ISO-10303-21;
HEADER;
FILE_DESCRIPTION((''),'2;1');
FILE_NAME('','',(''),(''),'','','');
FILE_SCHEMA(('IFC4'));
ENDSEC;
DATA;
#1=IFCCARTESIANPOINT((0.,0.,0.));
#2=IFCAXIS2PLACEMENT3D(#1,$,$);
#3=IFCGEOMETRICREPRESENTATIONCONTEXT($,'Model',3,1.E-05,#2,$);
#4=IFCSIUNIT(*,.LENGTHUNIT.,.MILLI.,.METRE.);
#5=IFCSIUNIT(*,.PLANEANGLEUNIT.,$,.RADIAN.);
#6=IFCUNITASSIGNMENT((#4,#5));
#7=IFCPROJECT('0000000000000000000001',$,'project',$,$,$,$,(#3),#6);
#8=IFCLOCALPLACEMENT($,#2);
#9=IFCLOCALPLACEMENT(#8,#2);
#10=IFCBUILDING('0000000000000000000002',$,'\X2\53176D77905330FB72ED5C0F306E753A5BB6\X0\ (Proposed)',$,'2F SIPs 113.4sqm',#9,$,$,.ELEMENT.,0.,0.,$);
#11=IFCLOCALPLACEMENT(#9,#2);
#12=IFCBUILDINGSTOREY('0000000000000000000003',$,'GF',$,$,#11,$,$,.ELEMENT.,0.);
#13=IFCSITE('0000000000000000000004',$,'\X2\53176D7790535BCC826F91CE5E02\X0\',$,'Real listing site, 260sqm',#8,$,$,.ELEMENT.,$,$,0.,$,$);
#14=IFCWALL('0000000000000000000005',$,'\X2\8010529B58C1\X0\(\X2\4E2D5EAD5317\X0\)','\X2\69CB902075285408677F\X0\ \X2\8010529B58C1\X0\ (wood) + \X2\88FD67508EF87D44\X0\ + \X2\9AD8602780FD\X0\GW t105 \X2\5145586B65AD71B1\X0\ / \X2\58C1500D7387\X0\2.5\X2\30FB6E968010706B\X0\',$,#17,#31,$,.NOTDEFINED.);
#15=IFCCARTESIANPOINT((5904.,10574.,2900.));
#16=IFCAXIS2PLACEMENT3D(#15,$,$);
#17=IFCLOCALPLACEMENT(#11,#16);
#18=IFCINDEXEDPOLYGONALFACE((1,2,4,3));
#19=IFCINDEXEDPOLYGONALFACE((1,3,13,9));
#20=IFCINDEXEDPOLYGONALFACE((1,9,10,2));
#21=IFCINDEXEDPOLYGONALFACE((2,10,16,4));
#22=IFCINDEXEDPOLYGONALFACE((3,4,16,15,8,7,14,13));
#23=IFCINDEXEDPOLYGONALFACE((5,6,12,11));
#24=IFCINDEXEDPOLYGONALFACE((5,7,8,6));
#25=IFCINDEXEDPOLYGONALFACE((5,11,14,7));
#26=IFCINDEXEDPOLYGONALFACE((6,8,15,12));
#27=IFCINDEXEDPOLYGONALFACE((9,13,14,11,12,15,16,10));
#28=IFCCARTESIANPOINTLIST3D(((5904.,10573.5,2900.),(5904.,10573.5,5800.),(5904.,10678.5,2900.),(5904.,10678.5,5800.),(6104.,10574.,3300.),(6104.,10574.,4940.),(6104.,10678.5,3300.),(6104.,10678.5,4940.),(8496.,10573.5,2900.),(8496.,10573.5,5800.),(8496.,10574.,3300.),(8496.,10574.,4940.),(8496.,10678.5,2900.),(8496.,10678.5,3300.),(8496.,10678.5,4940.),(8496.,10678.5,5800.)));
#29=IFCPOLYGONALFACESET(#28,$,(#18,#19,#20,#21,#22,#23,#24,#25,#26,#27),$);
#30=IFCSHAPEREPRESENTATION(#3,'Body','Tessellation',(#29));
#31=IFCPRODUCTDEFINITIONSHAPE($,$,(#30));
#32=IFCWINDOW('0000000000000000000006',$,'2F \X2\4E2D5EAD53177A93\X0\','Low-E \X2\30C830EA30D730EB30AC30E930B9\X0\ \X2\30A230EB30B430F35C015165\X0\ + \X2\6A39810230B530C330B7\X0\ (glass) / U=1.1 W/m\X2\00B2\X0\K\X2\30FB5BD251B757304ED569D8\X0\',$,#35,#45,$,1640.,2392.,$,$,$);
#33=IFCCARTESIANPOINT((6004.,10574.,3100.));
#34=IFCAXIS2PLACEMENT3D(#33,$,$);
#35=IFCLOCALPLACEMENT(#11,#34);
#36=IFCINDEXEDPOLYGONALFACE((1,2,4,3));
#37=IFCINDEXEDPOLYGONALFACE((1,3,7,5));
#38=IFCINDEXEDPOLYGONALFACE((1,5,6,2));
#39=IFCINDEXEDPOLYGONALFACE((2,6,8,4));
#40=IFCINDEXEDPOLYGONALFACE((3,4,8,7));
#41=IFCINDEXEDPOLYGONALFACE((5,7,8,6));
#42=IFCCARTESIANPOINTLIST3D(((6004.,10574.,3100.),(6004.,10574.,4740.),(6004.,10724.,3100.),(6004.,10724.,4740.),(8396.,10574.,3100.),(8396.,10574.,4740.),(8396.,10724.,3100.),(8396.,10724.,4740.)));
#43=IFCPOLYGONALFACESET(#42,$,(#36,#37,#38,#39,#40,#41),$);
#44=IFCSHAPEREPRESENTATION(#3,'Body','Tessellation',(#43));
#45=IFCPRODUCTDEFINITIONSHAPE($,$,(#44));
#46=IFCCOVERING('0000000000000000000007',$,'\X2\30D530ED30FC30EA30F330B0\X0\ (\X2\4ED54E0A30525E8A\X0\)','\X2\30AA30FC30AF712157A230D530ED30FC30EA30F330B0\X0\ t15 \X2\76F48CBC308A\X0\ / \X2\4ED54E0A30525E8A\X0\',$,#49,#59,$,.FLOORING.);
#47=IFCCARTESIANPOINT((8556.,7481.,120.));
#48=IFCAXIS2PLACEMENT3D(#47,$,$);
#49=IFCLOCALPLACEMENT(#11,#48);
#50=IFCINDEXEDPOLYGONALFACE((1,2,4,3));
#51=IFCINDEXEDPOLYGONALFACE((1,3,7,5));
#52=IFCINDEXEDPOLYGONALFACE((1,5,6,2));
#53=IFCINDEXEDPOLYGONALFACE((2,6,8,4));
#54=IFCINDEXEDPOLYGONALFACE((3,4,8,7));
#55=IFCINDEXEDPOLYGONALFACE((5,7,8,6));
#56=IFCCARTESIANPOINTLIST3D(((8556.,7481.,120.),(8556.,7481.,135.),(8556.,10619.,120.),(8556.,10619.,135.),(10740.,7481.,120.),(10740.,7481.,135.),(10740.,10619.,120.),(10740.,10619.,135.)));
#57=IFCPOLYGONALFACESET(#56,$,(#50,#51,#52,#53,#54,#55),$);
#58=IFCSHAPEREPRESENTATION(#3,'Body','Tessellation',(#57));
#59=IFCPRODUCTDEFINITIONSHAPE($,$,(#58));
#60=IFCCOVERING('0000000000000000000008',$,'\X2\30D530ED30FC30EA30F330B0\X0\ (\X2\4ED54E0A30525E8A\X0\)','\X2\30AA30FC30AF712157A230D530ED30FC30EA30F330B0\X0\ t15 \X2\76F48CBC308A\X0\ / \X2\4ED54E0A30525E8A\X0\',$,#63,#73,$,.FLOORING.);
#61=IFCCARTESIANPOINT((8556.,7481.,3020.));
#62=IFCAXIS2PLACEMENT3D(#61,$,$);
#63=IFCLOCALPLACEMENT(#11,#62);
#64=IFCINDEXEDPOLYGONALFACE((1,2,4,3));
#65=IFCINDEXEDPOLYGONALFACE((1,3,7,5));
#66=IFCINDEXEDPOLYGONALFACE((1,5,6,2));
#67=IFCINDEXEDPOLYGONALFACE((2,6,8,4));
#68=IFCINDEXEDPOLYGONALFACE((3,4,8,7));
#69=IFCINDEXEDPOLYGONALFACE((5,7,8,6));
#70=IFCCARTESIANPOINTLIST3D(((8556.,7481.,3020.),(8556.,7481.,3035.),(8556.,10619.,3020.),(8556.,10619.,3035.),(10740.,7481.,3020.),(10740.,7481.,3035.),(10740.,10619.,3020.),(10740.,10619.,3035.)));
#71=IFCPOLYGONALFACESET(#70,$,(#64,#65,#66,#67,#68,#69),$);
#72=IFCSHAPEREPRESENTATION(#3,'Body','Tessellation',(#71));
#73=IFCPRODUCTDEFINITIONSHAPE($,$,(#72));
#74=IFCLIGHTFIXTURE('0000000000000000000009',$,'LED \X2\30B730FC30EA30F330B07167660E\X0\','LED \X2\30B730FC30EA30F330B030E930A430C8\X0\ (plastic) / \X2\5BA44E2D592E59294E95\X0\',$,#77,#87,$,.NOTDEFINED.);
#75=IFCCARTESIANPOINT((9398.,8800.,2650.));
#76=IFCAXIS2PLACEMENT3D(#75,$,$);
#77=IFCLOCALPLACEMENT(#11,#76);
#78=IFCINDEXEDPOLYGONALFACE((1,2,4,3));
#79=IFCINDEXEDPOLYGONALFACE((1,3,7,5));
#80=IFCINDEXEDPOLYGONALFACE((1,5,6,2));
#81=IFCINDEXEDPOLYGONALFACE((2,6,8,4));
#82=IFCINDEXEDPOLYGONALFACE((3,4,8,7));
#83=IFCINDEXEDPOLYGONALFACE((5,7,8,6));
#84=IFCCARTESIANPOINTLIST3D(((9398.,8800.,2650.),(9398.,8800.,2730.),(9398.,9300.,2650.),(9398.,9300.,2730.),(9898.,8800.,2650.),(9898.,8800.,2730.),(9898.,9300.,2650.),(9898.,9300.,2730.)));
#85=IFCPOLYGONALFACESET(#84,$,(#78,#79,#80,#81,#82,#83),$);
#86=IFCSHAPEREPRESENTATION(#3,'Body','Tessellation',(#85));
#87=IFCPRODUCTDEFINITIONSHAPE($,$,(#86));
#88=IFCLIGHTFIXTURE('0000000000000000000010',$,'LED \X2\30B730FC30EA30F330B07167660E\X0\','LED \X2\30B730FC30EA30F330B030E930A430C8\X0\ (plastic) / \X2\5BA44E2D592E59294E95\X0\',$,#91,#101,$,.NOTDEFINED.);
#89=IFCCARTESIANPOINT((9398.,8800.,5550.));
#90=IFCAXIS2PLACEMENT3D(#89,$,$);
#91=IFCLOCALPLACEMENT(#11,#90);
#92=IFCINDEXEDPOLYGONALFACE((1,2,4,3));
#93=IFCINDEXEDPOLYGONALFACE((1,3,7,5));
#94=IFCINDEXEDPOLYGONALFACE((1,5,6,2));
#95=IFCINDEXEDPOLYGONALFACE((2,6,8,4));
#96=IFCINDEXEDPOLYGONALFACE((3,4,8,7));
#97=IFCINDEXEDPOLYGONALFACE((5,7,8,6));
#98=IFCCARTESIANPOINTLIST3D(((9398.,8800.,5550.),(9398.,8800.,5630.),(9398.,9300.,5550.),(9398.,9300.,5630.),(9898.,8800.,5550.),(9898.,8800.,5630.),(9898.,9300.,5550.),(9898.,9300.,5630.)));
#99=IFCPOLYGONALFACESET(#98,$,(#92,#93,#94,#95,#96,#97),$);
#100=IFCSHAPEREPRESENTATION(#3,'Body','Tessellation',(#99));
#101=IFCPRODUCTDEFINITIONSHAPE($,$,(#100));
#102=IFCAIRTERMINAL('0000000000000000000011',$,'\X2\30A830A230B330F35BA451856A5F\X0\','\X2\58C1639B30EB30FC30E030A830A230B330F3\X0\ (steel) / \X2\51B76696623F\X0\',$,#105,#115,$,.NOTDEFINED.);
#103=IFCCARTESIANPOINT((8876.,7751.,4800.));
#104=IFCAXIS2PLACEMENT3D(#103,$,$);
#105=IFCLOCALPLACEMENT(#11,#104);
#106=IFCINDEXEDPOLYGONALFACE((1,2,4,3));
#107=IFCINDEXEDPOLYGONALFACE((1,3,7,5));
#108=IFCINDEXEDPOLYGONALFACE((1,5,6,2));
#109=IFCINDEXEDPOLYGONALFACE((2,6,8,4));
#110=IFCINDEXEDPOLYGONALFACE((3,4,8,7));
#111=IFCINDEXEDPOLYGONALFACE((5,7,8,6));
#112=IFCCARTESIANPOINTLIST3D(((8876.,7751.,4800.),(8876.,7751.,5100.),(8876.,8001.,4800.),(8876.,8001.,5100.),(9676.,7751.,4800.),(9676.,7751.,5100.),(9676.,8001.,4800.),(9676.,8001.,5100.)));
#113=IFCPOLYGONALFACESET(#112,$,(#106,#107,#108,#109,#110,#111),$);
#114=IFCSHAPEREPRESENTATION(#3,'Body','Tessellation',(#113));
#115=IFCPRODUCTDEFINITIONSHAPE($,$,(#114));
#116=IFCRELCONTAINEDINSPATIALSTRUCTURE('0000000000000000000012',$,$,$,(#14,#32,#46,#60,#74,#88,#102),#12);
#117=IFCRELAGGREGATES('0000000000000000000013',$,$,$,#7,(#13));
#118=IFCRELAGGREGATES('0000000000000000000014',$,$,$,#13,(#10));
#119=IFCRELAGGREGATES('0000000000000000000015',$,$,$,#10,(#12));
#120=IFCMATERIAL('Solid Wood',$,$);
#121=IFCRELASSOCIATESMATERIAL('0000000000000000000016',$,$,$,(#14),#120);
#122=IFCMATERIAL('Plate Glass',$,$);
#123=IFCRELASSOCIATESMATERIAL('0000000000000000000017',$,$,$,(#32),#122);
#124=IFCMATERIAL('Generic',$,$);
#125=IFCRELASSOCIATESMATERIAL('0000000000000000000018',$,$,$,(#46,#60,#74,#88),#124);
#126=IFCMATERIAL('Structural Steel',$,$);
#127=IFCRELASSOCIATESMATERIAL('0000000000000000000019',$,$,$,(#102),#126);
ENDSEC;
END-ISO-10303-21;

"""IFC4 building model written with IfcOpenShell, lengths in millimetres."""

from ifc_helpers import new_model, si_unit, frame, frame_2d, origin, place, context, project, spatial, rectangle, extrude, material, element, fill, save


model = new_model("IFC4")

# Units and contexts
model_context = context("Model", 3, precision=1e-05, world=origin())
ifc_project = project(units=[si_unit("LENGTHUNIT", "METRE", prefix="MILLI"), si_unit("PLANEANGLEUNIT", "RADIAN")], contexts=[model_context])

# Site, building, storey
site_placement = place(None, origin())
site = spatial("IfcSite", under=ifc_project, at=site_placement, Name="北海道富良野市", ObjectType="Real listing site, 260sqm", CompositionType="ELEMENT", RefElevation=0.0)
building_placement = place(site_placement, origin())
building = spatial("IfcBuilding", under=site, at=building_placement, Name="北海道・狭小の町家 (Proposed)", ObjectType="2F SIPs 113.4sqm", CompositionType="ELEMENT", ElevationOfRefHeight=0.0, ElevationOfTerrain=0.0)
storey_placement = place(building_placement, origin())
storey = spatial("IfcBuildingStorey", under=building, at=storey_placement, Name="GF", CompositionType="ELEMENT", Elevation=0.0)

# Shared definitions
ifc_material_1 = material(Name="Solid Wood")

# Wall, opening, window
ifc_material_2 = material(Name="Plate Glass")
wall_1_placement = place(storey_placement, frame((5904.0, 10574.0, 2900.0)))
wall_1 = element("IfcWall", 1, at=wall_1_placement, inside=storey, material=ifc_material_1, Name="耐力壁(中庭北)", Description="構造用合板 耐力壁 (wood) + 製材軸組 + 高性能GW t105 充填断熱 / 壁倍率2.5・準耐火", PredefinedType="NOTDEFINED", context=model_context, shape_type="SweptSolid", body=[
    extrude(rectangle(XDim=2592.0, YDim=105.0, at=frame_2d((1296.0, 52.0))), frame((5904.0, 10574.0, 2900.0)), (0.0, 0.0, 1.0), 2900.0),
])
opening_1_placement = place(storey_placement, frame((6004.0, 10574.0, 3100.0)))
opening_1 = element("IfcOpeningElement", 2, at=opening_1_placement, cuts=wall_1, PredefinedType="NOTDEFINED", context=model_context, shape_type="SweptSolid", body=[
    extrude(rectangle(XDim=2392.0, YDim=150.0, at=frame_2d((1196.0, 75.0))), frame((6004.0, 10574.0, 3100.0)), (0.0, 0.0, 1.0), 1640.0),
])
window_1_placement = place(storey_placement, frame((6004.0, 10574.0, 3100.0)))
window_1 = element("IfcWindow", 3, at=window_1_placement, inside=storey, material=ifc_material_2, Name="2F 中庭北窓", Description="Low-E トリプルガラス アルゴン封入 + 樹脂サッシ (glass) / U=1.1 W/m²K・寒冷地仕様", OverallHeight=1640.0, OverallWidth=2392.0, context=model_context, shape_type="SweptSolid", body=[
    extrude(rectangle(XDim=2392.0, YDim=150.0, at=frame_2d((1196.0, 75.0))), frame((6004.0, 10574.0, 3100.0)), (0.0, 0.0, 1.0), 1640.0),
])
fill(opening_1, window_1)

# Coverings
ifc_material_3 = material(Name="Generic")
covering_1_placement = place(storey_placement, frame((8556.0, 7481.0, 120.0)))
element("IfcCovering", 4, at=covering_1_placement, inside=storey, material=ifc_material_3, Name="フローリング (仕上げ床)", Description="オーク無垢フローリング t15 直貼り / 仕上げ床", PredefinedType="FLOORING", context=model_context, shape_type="SweptSolid", body=[
    extrude(rectangle(XDim=2184.0, YDim=3138.0, at=frame_2d((1092.0, 1569.0))), frame((8556.0, 7481.0, 120.0)), (0.0, 0.0, 1.0), 15.0),
])
covering_2_placement = place(storey_placement, frame((8556.0, 7481.0, 3020.0)))
element("IfcCovering", 5, at=covering_2_placement, inside=storey, material=ifc_material_3, Name="フローリング (仕上げ床)", Description="オーク無垢フローリング t15 直貼り / 仕上げ床", PredefinedType="FLOORING", context=model_context, shape_type="SweptSolid", body=[
    extrude(rectangle(XDim=2184.0, YDim=3138.0, at=frame_2d((1092.0, 1569.0))), frame((8556.0, 7481.0, 3020.0)), (0.0, 0.0, 1.0), 15.0),
])

# Light fixtures
light_fixture_1_placement = place(storey_placement, frame((9398.0, 8800.0, 2650.0)))
element("IfcLightFixture", 6, at=light_fixture_1_placement, inside=storey, material=ifc_material_3, Name="LED シーリング照明", Description="LED シーリングライト (plastic) / 室中央天井", PredefinedType="NOTDEFINED", context=model_context, shape_type="SweptSolid", body=[
    extrude(rectangle(XDim=500.0, YDim=500.0, at=frame_2d((250.0, 250.0))), frame((9398.0, 8800.0, 2650.0)), (0.0, 0.0, 1.0), 80.0),
])
light_fixture_2_placement = place(storey_placement, frame((9398.0, 8800.0, 5550.0)))
element("IfcLightFixture", 7, at=light_fixture_2_placement, inside=storey, material=ifc_material_3, Name="LED シーリング照明", Description="LED シーリングライト (plastic) / 室中央天井", PredefinedType="NOTDEFINED", context=model_context, shape_type="SweptSolid", body=[
    extrude(rectangle(XDim=500.0, YDim=500.0, at=frame_2d((250.0, 250.0))), frame((9398.0, 8800.0, 5550.0)), (0.0, 0.0, 1.0), 80.0),
])

# Air terminal
ifc_material_4 = material(Name="Structural Steel")
air_terminal_placement = place(storey_placement, frame((8876.0, 7751.0, 4800.0)))
element("IfcAirTerminal", 8, at=air_terminal_placement, inside=storey, material=ifc_material_4, Name="エアコン室内機", Description="壁掛ルームエアコン (steel) / 冷暖房", PredefinedType="NOTDEFINED", context=model_context, shape_type="SweptSolid", body=[
    extrude(rectangle(XDim=800.0, YDim=250.0, at=frame_2d((400.0, 125.0))), frame((8876.0, 7751.0, 4800.0)), (0.0, 0.0, 1.0), 300.0),
])

save(model, "model.ifc")
